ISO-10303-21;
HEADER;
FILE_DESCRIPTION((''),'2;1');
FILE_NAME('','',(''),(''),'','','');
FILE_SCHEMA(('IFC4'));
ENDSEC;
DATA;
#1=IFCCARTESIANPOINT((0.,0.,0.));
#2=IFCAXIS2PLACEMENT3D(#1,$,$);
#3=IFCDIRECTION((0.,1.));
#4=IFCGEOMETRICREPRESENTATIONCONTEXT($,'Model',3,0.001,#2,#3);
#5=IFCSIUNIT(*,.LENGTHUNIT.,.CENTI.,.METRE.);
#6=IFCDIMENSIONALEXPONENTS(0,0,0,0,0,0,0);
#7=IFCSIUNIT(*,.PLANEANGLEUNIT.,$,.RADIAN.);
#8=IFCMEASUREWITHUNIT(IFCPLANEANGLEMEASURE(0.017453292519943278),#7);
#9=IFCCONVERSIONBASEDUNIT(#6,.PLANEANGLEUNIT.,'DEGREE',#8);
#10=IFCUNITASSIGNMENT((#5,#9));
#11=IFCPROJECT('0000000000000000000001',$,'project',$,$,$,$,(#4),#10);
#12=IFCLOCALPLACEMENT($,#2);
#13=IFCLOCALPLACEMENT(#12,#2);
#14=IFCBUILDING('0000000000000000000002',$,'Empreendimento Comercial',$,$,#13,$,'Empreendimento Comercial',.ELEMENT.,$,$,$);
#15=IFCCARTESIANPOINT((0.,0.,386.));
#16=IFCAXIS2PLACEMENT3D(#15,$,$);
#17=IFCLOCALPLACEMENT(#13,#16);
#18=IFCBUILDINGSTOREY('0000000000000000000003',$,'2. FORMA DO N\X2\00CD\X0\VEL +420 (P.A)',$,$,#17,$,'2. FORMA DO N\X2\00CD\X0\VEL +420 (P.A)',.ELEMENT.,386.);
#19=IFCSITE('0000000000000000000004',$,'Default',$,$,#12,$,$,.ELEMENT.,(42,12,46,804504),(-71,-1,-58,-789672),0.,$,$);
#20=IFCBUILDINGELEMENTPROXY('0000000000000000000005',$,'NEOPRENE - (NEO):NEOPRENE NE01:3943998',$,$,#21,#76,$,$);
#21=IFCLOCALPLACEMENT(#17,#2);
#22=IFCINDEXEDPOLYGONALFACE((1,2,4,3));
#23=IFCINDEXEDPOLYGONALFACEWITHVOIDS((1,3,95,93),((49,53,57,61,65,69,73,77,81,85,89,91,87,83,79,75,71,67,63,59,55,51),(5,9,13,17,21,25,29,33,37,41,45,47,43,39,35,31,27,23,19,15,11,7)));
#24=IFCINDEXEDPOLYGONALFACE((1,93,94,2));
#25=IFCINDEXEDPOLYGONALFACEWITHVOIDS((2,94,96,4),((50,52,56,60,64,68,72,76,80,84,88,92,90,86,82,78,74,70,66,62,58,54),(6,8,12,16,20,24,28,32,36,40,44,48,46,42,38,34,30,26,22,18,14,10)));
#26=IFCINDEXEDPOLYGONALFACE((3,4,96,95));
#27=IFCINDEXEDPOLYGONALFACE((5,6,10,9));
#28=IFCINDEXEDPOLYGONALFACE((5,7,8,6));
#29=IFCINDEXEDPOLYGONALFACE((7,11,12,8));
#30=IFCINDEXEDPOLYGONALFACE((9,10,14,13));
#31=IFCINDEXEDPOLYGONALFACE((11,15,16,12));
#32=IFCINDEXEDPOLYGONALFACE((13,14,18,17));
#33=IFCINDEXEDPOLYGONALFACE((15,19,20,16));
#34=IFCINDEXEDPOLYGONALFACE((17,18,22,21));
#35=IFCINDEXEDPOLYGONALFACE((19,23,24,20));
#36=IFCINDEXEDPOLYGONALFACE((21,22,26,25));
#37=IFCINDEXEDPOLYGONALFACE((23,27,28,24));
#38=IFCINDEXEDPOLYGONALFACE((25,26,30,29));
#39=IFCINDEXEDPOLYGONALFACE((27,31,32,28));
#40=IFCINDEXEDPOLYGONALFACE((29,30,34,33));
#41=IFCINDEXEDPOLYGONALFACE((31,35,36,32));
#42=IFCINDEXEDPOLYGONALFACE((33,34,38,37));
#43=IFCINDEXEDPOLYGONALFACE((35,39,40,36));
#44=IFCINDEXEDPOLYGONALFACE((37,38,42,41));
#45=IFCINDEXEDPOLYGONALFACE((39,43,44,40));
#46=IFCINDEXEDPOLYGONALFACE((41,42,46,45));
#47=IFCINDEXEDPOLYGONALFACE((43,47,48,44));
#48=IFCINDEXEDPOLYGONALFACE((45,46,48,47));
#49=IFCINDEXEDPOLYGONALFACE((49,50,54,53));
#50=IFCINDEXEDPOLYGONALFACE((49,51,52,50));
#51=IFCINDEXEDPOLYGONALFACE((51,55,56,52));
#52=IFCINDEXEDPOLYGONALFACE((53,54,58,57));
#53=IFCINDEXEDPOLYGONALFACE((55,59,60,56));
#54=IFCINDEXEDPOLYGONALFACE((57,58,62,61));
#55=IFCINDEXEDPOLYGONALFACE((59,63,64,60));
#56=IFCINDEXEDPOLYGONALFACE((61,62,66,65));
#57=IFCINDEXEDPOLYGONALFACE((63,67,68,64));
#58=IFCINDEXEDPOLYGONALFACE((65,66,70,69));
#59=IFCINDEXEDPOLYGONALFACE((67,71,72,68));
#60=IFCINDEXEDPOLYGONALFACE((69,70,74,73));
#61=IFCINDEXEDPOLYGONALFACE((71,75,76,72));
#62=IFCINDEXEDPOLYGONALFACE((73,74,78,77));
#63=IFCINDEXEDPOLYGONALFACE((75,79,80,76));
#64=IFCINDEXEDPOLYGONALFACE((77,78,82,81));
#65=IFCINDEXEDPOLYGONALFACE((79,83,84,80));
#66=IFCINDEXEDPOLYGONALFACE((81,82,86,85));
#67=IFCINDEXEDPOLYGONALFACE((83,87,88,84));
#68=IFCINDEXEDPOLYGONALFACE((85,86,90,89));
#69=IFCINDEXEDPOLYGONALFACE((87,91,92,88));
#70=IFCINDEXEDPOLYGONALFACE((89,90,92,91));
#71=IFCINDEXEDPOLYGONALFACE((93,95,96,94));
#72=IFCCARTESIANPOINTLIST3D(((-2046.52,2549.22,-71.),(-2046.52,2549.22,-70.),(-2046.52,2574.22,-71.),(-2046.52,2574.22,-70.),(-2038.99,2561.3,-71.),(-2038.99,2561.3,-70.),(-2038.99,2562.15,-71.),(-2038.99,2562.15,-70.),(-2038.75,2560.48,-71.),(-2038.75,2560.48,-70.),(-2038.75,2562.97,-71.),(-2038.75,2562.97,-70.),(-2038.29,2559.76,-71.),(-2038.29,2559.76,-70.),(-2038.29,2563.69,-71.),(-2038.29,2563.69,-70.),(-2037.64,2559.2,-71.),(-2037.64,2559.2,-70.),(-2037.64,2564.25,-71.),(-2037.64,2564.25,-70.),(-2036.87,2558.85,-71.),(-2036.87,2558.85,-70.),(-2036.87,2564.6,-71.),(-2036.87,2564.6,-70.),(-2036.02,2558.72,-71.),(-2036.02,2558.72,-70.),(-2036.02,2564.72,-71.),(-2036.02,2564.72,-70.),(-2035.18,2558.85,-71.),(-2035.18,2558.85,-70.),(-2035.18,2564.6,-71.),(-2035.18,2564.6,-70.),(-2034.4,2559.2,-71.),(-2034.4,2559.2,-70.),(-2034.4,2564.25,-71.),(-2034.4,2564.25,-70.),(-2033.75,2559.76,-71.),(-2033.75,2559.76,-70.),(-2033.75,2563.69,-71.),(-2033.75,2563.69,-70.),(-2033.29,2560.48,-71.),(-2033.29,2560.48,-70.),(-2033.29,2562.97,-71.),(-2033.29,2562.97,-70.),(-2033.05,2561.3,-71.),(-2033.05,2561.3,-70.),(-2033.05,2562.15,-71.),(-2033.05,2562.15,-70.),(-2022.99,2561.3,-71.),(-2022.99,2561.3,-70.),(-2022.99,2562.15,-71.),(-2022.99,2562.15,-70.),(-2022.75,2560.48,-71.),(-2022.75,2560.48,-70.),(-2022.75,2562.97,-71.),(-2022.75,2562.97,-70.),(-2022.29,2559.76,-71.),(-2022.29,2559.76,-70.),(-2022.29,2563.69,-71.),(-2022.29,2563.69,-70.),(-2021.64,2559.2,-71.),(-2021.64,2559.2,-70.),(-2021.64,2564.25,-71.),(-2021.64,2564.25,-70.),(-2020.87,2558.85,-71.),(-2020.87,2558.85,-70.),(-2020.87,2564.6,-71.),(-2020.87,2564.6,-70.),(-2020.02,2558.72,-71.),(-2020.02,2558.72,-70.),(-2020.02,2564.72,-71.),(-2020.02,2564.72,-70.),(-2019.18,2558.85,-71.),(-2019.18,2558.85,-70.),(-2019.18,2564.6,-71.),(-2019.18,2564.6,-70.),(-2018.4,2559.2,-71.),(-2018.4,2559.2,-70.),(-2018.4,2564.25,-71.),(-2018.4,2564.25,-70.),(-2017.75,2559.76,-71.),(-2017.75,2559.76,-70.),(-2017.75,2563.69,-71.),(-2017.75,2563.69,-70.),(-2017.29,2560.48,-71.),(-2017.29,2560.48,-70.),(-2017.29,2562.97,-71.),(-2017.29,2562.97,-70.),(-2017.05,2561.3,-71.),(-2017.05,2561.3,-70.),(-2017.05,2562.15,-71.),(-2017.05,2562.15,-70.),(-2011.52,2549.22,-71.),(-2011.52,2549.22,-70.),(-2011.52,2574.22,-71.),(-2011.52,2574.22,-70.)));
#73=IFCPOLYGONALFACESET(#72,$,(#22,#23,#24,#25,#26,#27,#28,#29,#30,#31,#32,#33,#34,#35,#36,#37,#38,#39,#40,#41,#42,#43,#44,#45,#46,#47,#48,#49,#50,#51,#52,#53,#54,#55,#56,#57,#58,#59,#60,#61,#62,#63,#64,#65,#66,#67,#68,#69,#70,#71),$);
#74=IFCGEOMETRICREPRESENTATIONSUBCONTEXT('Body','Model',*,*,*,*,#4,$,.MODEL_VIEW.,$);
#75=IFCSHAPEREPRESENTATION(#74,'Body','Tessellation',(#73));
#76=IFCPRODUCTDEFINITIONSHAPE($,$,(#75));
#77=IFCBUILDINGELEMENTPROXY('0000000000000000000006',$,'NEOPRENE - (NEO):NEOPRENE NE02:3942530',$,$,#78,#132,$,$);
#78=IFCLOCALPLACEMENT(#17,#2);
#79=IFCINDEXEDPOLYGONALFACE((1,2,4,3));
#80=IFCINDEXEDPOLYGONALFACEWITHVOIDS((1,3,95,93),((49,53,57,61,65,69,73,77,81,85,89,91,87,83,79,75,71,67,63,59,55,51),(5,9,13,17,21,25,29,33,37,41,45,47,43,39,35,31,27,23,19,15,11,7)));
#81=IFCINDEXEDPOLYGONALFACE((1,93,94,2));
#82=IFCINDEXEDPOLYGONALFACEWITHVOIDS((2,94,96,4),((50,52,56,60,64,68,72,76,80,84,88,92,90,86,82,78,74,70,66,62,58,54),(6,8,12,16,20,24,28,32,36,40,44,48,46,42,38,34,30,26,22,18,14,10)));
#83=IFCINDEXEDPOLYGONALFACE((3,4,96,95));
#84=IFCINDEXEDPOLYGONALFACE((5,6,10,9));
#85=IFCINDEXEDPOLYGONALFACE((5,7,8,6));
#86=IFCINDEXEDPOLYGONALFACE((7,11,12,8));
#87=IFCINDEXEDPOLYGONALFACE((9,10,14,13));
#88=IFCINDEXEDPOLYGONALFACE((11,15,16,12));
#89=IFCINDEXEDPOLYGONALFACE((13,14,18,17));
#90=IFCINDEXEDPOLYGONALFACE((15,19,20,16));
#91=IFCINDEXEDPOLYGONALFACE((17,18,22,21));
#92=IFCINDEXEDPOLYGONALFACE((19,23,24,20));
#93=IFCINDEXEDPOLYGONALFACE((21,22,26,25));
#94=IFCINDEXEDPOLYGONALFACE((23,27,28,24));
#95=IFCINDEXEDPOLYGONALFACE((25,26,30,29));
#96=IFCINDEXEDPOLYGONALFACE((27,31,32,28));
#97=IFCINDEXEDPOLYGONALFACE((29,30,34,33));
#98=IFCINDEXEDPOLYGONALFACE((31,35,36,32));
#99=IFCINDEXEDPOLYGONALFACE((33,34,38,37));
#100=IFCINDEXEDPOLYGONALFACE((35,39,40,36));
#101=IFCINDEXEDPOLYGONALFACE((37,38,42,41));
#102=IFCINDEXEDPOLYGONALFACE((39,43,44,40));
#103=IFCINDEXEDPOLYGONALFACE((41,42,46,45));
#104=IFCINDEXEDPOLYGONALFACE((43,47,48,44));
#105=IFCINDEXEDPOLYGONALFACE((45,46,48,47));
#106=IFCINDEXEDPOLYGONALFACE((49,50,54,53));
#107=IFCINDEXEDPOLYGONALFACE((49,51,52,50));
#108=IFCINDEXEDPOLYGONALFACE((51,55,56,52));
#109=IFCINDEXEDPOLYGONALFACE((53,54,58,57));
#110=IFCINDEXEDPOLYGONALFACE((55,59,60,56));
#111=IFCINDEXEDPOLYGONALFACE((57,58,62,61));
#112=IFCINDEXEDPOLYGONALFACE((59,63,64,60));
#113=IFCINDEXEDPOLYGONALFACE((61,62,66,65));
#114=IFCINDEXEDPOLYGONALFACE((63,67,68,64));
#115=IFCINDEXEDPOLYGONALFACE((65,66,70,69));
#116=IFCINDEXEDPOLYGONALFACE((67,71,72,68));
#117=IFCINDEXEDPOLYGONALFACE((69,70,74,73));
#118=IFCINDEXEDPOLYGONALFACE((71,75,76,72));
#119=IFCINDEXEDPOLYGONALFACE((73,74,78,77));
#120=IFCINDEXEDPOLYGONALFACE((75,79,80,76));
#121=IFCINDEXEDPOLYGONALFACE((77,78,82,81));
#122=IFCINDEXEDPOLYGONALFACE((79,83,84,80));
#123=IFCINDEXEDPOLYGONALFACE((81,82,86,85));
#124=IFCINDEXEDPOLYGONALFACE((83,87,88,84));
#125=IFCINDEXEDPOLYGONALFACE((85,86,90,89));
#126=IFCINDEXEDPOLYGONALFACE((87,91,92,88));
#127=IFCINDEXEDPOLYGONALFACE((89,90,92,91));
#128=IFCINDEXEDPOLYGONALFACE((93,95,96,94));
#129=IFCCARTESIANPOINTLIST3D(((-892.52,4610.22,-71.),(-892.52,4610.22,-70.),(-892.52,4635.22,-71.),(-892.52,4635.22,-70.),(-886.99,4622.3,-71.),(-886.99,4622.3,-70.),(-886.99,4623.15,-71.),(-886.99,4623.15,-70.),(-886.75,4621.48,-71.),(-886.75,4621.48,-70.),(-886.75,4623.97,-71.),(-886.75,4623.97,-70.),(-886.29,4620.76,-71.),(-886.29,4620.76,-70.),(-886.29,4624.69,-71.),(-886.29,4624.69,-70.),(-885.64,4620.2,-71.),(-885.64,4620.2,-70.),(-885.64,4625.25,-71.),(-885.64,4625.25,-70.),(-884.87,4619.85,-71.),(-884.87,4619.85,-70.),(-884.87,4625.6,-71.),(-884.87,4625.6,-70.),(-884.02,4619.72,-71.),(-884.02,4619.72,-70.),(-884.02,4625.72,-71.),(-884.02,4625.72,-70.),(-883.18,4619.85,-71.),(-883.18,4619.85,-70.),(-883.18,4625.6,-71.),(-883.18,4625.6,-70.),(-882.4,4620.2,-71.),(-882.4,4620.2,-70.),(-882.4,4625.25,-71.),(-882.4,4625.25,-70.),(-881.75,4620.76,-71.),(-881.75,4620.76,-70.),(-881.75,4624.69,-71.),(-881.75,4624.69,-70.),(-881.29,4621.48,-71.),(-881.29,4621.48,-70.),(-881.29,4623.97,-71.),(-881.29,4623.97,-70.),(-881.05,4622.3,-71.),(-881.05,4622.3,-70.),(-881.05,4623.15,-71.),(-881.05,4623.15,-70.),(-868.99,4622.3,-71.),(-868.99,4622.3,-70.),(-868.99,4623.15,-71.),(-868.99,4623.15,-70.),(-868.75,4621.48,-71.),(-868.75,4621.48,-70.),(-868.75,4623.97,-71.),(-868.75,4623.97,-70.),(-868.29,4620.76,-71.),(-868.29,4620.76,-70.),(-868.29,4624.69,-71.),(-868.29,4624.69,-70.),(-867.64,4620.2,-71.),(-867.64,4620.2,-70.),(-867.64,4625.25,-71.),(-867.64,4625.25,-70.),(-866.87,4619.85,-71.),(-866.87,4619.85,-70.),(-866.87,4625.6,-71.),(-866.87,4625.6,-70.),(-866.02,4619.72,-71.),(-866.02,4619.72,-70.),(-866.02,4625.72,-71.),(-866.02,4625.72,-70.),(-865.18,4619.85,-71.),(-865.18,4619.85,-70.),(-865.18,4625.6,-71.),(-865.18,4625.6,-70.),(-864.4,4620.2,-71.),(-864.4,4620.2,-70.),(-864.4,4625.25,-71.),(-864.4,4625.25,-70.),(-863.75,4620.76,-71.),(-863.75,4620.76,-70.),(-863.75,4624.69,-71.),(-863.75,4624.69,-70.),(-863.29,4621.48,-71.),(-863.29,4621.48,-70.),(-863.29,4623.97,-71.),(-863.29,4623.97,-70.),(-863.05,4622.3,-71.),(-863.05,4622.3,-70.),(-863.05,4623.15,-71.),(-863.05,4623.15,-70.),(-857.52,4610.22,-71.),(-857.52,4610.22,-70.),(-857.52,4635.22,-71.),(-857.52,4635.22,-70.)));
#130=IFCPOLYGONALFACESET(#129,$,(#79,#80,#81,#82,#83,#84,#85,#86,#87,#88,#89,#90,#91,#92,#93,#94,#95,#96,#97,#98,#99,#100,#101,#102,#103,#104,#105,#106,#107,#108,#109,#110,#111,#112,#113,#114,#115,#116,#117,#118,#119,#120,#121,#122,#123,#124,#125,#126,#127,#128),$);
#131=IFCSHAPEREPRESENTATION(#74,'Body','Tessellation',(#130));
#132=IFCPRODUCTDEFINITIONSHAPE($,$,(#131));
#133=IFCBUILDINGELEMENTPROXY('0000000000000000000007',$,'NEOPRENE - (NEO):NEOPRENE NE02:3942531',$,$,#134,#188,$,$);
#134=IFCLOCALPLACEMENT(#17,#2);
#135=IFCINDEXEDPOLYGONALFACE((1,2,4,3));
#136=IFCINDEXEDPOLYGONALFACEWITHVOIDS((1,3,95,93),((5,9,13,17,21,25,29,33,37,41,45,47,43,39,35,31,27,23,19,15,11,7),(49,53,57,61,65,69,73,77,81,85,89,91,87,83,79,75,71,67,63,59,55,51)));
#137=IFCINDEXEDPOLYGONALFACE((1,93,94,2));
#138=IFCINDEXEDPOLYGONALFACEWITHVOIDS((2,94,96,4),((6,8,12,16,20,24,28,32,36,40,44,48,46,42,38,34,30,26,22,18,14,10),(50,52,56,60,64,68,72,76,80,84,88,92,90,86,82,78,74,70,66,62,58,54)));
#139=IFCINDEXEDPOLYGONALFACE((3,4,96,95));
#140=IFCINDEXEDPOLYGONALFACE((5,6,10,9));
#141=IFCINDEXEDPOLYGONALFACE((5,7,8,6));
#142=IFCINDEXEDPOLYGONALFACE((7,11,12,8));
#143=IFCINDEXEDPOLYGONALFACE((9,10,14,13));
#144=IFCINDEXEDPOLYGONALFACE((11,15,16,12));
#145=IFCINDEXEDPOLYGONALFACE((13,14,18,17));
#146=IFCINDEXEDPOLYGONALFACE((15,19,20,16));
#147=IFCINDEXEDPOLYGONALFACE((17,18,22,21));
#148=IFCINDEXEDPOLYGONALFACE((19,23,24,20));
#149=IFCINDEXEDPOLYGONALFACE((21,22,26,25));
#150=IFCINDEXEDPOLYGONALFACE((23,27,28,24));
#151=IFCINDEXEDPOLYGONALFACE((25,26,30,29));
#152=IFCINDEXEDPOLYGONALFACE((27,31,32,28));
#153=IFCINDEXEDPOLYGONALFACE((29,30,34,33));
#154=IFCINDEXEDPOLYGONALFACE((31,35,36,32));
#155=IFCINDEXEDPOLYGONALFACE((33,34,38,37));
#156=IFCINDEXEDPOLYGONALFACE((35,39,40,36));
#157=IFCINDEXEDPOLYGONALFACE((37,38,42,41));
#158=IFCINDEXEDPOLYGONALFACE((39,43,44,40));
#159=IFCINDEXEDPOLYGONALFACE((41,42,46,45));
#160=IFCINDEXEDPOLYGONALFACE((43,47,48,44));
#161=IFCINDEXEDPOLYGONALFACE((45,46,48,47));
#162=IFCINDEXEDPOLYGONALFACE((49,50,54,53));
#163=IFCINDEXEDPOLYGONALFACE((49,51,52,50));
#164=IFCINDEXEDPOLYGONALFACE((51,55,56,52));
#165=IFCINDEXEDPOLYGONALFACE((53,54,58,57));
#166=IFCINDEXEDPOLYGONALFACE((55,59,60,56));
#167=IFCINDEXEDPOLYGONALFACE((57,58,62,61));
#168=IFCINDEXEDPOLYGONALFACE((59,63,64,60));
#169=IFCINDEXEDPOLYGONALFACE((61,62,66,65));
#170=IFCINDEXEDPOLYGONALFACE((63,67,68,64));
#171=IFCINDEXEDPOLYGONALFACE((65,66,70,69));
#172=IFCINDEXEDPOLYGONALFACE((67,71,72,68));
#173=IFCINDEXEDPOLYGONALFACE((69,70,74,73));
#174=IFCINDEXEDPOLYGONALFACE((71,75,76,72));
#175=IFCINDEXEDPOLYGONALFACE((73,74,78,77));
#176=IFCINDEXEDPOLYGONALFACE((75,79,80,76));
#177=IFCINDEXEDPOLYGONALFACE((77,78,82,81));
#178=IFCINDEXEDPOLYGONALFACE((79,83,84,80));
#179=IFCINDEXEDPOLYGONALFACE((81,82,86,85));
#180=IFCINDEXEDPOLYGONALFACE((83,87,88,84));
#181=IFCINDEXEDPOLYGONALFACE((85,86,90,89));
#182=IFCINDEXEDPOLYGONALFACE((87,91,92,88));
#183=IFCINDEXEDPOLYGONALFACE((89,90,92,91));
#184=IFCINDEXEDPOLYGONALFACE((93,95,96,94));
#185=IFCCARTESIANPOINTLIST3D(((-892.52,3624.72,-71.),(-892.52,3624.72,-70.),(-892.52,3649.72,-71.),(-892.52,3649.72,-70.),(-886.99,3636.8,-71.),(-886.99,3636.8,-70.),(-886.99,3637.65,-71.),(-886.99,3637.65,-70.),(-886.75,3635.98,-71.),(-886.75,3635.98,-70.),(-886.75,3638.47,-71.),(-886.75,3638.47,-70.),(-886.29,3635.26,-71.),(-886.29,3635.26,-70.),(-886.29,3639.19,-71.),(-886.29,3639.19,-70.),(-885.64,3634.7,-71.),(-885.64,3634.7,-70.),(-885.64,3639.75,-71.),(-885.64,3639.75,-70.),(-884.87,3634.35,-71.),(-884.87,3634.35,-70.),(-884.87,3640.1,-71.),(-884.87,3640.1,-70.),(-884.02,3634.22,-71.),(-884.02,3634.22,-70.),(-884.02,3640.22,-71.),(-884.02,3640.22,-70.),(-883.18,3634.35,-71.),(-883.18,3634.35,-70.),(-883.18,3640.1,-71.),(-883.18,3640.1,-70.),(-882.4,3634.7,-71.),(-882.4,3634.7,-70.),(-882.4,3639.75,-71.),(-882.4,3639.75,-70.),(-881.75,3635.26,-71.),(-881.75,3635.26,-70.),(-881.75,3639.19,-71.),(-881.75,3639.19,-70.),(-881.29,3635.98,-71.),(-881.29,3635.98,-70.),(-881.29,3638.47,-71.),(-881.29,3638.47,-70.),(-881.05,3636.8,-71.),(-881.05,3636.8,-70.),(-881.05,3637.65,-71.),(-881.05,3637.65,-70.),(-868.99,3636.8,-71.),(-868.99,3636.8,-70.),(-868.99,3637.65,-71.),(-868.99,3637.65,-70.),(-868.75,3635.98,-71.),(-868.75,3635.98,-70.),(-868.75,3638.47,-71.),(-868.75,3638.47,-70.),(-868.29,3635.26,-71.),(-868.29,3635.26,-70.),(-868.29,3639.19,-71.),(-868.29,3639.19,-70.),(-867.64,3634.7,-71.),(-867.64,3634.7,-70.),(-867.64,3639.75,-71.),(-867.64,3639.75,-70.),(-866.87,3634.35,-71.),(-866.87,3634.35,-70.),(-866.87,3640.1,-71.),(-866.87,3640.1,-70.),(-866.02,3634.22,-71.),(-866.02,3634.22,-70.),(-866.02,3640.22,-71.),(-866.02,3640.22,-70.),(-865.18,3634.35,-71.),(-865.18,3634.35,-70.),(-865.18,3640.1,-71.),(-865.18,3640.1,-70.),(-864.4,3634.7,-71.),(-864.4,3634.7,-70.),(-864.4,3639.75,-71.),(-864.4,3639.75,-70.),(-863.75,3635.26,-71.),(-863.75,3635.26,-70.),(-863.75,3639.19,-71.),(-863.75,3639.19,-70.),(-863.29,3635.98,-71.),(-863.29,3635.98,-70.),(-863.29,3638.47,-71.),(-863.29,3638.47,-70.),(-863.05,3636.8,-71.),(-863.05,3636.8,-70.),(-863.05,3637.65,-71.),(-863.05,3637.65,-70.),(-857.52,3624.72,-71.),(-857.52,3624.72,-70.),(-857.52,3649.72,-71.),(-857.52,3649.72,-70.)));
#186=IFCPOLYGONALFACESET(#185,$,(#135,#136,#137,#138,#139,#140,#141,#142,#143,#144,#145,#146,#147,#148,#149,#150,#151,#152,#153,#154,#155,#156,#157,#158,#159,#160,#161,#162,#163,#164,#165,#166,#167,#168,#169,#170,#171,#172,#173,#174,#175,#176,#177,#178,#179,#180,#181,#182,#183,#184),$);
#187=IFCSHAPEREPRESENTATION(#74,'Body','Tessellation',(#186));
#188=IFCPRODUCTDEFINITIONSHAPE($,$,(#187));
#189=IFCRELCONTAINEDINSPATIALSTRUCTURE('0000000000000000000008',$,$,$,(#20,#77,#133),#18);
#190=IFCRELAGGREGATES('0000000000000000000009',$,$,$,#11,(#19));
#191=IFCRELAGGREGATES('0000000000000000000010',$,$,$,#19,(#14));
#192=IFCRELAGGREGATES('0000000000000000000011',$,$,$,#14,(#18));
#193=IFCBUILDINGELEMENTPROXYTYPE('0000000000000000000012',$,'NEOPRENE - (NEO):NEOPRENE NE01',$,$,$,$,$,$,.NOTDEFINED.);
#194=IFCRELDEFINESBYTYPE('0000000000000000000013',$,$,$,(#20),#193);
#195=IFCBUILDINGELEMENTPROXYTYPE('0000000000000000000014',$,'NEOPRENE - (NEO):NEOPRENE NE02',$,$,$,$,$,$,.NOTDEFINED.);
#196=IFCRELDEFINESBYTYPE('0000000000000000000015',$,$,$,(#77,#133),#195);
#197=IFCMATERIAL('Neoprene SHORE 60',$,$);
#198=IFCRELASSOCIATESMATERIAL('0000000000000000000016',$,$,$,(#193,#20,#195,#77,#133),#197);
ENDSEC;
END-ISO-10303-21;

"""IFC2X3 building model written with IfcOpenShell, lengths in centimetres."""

from ifc_helpers import new_model, entity, si_unit, converted_unit, direction, frame, frame_2d, origin, place, context, subcontext, project, spatial, polyline, circle_curve, parameter, trimmed, segment, composite_curve, outline, extrude, source, transform, mapped, material, type_object, type_shapes, element, save


model = new_model("IFC2X3")

# Units and contexts
model_context = context("Model", 3, precision=0.001, world=origin(), true_north=direction((0.0, 1.0)))
body_context = subcontext(model_context, "Body", "Model", "MODEL_VIEW")
ifc_project = project(units=[si_unit("LENGTHUNIT", "METRE", prefix="CENTI"), converted_unit("PLANEANGLEUNIT", "DEGREE", entity("IfcPlaneAngleMeasure", 0.017453292519943278), si_unit("PLANEANGLEUNIT", "RADIAN"), dimensions=[0, 0, 0, 0, 0, 0, 0])], contexts=[model_context])

# Site, building, storey
site_placement = place(None, origin())
site = spatial("IfcSite", under=ifc_project, at=site_placement, Name="Default", CompositionType="ELEMENT", RefLatitude=(42, 12, 46, 804504), RefLongitude=(-71, -1, -58, -789672), RefElevation=0.0)
building_placement = place(site_placement, origin())
building = spatial("IfcBuilding", under=site, at=building_placement, Name="Empreendimento Comercial", LongName="Empreendimento Comercial", CompositionType="ELEMENT")
storey_placement = place(building_placement, frame((0.0, 0.0, 386.0)))
storey = spatial("IfcBuildingStorey", under=building, at=storey_placement, Name="2. FORMA DO NÍVEL +420 (P.A)", LongName="2. FORMA DO NÍVEL +420 (P.A)", CompositionType="ELEMENT", Elevation=386.0)

# Building element proxies
ifc_material = material(Name="Neoprene SHORE 60")
building_element_proxy_type_1 = type_object("IfcBuildingElementProxyType", Name="NEOPRENE - (NEO):NEOPRENE NE01", PredefinedType="NOTDEFINED", material=ifc_material)
shared_shape_1 = source(origin(), body_context, "Body", "SweptSolid", [
    extrude(outline(polyline([(-17.5, -12.5), (17.5, -12.5), (17.5, 12.5), (-17.5, 12.5), (-17.5, -12.5)]), holes=[composite_curve([segment(trimmed(circle_curve(frame_2d((-9.0, 0.0), x_axis=(0.0, -1.0)), 3.0), [parameter(0.0)], [parameter(180.0)], True, "PARAMETER"), False, "CONTINUOUS"), segment(trimmed(circle_curve(frame_2d((-9.0, 0.0), x_axis=(0.0, -1.0)), 3.0), [parameter(180.0)], [parameter(0.0)], True, "PARAMETER"), False, "CONTINUOUS")], self_intersect=False), composite_curve([segment(trimmed(circle_curve(frame_2d((7.0, 0.0), x_axis=(0.0, -1.0)), 3.0), [parameter(0.0)], [parameter(180.0)], True, "PARAMETER"), False, "CONTINUOUS"), segment(trimmed(circle_curve(frame_2d((7.0, 0.0), x_axis=(0.0, -1.0)), 3.0), [parameter(180.0)], [parameter(0.0)], True, "PARAMETER"), False, "CONTINUOUS")], self_intersect=False)]), frame((0.0, 0.0, -71.0), z_axis=(0.0, 0.0, 1.0), x_axis=(0.0, 1.0, 0.0)), (0.0, 0.0, 1.0), 1.0),
])
type_shapes(building_element_proxy_type_1, [shared_shape_1])
for number, where, z_axis, x_axis, name in (
    (1, (-2029.02, 2561.72, 0.0), (0.0, 0.0, 1.0), (0.0, 1.0, 0.0), "NEOPRENE - (NEO):NEOPRENE NE01:3943998"),
):
    element("IfcBuildingElementProxy", number, at=place(storey_placement, frame(where, z_axis=z_axis, x_axis=x_axis)), inside=storey, type_object=building_element_proxy_type_1, material=ifc_material, Name=name, context=body_context, shape_type="MappedRepresentation", body=[
        mapped(shared_shape_1, transform((0.0, 0.0, 0.0), scale=1.0)),
    ])
building_element_proxy_type_2 = type_object("IfcBuildingElementProxyType", Name="NEOPRENE - (NEO):NEOPRENE NE02", PredefinedType="NOTDEFINED", material=ifc_material)
shared_shape_2 = source(origin(), body_context, "Body", "SweptSolid", [
    extrude(outline(polyline([(-17.5, -12.5), (17.5, -12.5), (17.5, 12.5), (-17.5, 12.5), (-17.5, -12.5)]), holes=[composite_curve([segment(trimmed(circle_curve(frame_2d((-9.0, 0.0), x_axis=(0.0, -1.0)), 3.0), [parameter(0.0)], [parameter(180.0)], True, "PARAMETER"), False, "CONTINUOUS"), segment(trimmed(circle_curve(frame_2d((-9.0, 0.0), x_axis=(0.0, -1.0)), 3.0), [parameter(180.0)], [parameter(0.0)], True, "PARAMETER"), False, "CONTINUOUS")], self_intersect=False), composite_curve([segment(trimmed(circle_curve(frame_2d((9.0, 0.0), x_axis=(0.0, -1.0)), 3.0), [parameter(0.0)], [parameter(180.0)], True, "PARAMETER"), False, "CONTINUOUS"), segment(trimmed(circle_curve(frame_2d((9.0, 0.0), x_axis=(0.0, -1.0)), 3.0), [parameter(180.0)], [parameter(0.0)], True, "PARAMETER"), False, "CONTINUOUS")], self_intersect=False)]), frame((0.0, 0.0, -71.0), z_axis=(0.0, 0.0, 1.0), x_axis=(0.0, 1.0, 0.0)), (0.0, 0.0, 1.0), 1.0),
])
type_shapes(building_element_proxy_type_2, [shared_shape_2])
for number, where, z_axis, x_axis, name in (
    (2, (-875.02, 4622.72, 0.0), (0.0, 0.0, 1.0), (0.0, 1.0, 0.0), "NEOPRENE - (NEO):NEOPRENE NE02:3942530"),
    (3, (-875.02, 3637.22, 0.0), (0.0, 0.0, 1.0), (0.0, 1.0, 0.0), "NEOPRENE - (NEO):NEOPRENE NE02:3942531"),
):
    element("IfcBuildingElementProxy", number, at=place(storey_placement, frame(where, z_axis=z_axis, x_axis=x_axis)), inside=storey, type_object=building_element_proxy_type_2, material=ifc_material, Name=name, context=body_context, shape_type="MappedRepresentation", body=[
        mapped(shared_shape_2, transform((0.0, 0.0, 0.0), scale=1.0)),
    ])

save(model, "model.ifc")
